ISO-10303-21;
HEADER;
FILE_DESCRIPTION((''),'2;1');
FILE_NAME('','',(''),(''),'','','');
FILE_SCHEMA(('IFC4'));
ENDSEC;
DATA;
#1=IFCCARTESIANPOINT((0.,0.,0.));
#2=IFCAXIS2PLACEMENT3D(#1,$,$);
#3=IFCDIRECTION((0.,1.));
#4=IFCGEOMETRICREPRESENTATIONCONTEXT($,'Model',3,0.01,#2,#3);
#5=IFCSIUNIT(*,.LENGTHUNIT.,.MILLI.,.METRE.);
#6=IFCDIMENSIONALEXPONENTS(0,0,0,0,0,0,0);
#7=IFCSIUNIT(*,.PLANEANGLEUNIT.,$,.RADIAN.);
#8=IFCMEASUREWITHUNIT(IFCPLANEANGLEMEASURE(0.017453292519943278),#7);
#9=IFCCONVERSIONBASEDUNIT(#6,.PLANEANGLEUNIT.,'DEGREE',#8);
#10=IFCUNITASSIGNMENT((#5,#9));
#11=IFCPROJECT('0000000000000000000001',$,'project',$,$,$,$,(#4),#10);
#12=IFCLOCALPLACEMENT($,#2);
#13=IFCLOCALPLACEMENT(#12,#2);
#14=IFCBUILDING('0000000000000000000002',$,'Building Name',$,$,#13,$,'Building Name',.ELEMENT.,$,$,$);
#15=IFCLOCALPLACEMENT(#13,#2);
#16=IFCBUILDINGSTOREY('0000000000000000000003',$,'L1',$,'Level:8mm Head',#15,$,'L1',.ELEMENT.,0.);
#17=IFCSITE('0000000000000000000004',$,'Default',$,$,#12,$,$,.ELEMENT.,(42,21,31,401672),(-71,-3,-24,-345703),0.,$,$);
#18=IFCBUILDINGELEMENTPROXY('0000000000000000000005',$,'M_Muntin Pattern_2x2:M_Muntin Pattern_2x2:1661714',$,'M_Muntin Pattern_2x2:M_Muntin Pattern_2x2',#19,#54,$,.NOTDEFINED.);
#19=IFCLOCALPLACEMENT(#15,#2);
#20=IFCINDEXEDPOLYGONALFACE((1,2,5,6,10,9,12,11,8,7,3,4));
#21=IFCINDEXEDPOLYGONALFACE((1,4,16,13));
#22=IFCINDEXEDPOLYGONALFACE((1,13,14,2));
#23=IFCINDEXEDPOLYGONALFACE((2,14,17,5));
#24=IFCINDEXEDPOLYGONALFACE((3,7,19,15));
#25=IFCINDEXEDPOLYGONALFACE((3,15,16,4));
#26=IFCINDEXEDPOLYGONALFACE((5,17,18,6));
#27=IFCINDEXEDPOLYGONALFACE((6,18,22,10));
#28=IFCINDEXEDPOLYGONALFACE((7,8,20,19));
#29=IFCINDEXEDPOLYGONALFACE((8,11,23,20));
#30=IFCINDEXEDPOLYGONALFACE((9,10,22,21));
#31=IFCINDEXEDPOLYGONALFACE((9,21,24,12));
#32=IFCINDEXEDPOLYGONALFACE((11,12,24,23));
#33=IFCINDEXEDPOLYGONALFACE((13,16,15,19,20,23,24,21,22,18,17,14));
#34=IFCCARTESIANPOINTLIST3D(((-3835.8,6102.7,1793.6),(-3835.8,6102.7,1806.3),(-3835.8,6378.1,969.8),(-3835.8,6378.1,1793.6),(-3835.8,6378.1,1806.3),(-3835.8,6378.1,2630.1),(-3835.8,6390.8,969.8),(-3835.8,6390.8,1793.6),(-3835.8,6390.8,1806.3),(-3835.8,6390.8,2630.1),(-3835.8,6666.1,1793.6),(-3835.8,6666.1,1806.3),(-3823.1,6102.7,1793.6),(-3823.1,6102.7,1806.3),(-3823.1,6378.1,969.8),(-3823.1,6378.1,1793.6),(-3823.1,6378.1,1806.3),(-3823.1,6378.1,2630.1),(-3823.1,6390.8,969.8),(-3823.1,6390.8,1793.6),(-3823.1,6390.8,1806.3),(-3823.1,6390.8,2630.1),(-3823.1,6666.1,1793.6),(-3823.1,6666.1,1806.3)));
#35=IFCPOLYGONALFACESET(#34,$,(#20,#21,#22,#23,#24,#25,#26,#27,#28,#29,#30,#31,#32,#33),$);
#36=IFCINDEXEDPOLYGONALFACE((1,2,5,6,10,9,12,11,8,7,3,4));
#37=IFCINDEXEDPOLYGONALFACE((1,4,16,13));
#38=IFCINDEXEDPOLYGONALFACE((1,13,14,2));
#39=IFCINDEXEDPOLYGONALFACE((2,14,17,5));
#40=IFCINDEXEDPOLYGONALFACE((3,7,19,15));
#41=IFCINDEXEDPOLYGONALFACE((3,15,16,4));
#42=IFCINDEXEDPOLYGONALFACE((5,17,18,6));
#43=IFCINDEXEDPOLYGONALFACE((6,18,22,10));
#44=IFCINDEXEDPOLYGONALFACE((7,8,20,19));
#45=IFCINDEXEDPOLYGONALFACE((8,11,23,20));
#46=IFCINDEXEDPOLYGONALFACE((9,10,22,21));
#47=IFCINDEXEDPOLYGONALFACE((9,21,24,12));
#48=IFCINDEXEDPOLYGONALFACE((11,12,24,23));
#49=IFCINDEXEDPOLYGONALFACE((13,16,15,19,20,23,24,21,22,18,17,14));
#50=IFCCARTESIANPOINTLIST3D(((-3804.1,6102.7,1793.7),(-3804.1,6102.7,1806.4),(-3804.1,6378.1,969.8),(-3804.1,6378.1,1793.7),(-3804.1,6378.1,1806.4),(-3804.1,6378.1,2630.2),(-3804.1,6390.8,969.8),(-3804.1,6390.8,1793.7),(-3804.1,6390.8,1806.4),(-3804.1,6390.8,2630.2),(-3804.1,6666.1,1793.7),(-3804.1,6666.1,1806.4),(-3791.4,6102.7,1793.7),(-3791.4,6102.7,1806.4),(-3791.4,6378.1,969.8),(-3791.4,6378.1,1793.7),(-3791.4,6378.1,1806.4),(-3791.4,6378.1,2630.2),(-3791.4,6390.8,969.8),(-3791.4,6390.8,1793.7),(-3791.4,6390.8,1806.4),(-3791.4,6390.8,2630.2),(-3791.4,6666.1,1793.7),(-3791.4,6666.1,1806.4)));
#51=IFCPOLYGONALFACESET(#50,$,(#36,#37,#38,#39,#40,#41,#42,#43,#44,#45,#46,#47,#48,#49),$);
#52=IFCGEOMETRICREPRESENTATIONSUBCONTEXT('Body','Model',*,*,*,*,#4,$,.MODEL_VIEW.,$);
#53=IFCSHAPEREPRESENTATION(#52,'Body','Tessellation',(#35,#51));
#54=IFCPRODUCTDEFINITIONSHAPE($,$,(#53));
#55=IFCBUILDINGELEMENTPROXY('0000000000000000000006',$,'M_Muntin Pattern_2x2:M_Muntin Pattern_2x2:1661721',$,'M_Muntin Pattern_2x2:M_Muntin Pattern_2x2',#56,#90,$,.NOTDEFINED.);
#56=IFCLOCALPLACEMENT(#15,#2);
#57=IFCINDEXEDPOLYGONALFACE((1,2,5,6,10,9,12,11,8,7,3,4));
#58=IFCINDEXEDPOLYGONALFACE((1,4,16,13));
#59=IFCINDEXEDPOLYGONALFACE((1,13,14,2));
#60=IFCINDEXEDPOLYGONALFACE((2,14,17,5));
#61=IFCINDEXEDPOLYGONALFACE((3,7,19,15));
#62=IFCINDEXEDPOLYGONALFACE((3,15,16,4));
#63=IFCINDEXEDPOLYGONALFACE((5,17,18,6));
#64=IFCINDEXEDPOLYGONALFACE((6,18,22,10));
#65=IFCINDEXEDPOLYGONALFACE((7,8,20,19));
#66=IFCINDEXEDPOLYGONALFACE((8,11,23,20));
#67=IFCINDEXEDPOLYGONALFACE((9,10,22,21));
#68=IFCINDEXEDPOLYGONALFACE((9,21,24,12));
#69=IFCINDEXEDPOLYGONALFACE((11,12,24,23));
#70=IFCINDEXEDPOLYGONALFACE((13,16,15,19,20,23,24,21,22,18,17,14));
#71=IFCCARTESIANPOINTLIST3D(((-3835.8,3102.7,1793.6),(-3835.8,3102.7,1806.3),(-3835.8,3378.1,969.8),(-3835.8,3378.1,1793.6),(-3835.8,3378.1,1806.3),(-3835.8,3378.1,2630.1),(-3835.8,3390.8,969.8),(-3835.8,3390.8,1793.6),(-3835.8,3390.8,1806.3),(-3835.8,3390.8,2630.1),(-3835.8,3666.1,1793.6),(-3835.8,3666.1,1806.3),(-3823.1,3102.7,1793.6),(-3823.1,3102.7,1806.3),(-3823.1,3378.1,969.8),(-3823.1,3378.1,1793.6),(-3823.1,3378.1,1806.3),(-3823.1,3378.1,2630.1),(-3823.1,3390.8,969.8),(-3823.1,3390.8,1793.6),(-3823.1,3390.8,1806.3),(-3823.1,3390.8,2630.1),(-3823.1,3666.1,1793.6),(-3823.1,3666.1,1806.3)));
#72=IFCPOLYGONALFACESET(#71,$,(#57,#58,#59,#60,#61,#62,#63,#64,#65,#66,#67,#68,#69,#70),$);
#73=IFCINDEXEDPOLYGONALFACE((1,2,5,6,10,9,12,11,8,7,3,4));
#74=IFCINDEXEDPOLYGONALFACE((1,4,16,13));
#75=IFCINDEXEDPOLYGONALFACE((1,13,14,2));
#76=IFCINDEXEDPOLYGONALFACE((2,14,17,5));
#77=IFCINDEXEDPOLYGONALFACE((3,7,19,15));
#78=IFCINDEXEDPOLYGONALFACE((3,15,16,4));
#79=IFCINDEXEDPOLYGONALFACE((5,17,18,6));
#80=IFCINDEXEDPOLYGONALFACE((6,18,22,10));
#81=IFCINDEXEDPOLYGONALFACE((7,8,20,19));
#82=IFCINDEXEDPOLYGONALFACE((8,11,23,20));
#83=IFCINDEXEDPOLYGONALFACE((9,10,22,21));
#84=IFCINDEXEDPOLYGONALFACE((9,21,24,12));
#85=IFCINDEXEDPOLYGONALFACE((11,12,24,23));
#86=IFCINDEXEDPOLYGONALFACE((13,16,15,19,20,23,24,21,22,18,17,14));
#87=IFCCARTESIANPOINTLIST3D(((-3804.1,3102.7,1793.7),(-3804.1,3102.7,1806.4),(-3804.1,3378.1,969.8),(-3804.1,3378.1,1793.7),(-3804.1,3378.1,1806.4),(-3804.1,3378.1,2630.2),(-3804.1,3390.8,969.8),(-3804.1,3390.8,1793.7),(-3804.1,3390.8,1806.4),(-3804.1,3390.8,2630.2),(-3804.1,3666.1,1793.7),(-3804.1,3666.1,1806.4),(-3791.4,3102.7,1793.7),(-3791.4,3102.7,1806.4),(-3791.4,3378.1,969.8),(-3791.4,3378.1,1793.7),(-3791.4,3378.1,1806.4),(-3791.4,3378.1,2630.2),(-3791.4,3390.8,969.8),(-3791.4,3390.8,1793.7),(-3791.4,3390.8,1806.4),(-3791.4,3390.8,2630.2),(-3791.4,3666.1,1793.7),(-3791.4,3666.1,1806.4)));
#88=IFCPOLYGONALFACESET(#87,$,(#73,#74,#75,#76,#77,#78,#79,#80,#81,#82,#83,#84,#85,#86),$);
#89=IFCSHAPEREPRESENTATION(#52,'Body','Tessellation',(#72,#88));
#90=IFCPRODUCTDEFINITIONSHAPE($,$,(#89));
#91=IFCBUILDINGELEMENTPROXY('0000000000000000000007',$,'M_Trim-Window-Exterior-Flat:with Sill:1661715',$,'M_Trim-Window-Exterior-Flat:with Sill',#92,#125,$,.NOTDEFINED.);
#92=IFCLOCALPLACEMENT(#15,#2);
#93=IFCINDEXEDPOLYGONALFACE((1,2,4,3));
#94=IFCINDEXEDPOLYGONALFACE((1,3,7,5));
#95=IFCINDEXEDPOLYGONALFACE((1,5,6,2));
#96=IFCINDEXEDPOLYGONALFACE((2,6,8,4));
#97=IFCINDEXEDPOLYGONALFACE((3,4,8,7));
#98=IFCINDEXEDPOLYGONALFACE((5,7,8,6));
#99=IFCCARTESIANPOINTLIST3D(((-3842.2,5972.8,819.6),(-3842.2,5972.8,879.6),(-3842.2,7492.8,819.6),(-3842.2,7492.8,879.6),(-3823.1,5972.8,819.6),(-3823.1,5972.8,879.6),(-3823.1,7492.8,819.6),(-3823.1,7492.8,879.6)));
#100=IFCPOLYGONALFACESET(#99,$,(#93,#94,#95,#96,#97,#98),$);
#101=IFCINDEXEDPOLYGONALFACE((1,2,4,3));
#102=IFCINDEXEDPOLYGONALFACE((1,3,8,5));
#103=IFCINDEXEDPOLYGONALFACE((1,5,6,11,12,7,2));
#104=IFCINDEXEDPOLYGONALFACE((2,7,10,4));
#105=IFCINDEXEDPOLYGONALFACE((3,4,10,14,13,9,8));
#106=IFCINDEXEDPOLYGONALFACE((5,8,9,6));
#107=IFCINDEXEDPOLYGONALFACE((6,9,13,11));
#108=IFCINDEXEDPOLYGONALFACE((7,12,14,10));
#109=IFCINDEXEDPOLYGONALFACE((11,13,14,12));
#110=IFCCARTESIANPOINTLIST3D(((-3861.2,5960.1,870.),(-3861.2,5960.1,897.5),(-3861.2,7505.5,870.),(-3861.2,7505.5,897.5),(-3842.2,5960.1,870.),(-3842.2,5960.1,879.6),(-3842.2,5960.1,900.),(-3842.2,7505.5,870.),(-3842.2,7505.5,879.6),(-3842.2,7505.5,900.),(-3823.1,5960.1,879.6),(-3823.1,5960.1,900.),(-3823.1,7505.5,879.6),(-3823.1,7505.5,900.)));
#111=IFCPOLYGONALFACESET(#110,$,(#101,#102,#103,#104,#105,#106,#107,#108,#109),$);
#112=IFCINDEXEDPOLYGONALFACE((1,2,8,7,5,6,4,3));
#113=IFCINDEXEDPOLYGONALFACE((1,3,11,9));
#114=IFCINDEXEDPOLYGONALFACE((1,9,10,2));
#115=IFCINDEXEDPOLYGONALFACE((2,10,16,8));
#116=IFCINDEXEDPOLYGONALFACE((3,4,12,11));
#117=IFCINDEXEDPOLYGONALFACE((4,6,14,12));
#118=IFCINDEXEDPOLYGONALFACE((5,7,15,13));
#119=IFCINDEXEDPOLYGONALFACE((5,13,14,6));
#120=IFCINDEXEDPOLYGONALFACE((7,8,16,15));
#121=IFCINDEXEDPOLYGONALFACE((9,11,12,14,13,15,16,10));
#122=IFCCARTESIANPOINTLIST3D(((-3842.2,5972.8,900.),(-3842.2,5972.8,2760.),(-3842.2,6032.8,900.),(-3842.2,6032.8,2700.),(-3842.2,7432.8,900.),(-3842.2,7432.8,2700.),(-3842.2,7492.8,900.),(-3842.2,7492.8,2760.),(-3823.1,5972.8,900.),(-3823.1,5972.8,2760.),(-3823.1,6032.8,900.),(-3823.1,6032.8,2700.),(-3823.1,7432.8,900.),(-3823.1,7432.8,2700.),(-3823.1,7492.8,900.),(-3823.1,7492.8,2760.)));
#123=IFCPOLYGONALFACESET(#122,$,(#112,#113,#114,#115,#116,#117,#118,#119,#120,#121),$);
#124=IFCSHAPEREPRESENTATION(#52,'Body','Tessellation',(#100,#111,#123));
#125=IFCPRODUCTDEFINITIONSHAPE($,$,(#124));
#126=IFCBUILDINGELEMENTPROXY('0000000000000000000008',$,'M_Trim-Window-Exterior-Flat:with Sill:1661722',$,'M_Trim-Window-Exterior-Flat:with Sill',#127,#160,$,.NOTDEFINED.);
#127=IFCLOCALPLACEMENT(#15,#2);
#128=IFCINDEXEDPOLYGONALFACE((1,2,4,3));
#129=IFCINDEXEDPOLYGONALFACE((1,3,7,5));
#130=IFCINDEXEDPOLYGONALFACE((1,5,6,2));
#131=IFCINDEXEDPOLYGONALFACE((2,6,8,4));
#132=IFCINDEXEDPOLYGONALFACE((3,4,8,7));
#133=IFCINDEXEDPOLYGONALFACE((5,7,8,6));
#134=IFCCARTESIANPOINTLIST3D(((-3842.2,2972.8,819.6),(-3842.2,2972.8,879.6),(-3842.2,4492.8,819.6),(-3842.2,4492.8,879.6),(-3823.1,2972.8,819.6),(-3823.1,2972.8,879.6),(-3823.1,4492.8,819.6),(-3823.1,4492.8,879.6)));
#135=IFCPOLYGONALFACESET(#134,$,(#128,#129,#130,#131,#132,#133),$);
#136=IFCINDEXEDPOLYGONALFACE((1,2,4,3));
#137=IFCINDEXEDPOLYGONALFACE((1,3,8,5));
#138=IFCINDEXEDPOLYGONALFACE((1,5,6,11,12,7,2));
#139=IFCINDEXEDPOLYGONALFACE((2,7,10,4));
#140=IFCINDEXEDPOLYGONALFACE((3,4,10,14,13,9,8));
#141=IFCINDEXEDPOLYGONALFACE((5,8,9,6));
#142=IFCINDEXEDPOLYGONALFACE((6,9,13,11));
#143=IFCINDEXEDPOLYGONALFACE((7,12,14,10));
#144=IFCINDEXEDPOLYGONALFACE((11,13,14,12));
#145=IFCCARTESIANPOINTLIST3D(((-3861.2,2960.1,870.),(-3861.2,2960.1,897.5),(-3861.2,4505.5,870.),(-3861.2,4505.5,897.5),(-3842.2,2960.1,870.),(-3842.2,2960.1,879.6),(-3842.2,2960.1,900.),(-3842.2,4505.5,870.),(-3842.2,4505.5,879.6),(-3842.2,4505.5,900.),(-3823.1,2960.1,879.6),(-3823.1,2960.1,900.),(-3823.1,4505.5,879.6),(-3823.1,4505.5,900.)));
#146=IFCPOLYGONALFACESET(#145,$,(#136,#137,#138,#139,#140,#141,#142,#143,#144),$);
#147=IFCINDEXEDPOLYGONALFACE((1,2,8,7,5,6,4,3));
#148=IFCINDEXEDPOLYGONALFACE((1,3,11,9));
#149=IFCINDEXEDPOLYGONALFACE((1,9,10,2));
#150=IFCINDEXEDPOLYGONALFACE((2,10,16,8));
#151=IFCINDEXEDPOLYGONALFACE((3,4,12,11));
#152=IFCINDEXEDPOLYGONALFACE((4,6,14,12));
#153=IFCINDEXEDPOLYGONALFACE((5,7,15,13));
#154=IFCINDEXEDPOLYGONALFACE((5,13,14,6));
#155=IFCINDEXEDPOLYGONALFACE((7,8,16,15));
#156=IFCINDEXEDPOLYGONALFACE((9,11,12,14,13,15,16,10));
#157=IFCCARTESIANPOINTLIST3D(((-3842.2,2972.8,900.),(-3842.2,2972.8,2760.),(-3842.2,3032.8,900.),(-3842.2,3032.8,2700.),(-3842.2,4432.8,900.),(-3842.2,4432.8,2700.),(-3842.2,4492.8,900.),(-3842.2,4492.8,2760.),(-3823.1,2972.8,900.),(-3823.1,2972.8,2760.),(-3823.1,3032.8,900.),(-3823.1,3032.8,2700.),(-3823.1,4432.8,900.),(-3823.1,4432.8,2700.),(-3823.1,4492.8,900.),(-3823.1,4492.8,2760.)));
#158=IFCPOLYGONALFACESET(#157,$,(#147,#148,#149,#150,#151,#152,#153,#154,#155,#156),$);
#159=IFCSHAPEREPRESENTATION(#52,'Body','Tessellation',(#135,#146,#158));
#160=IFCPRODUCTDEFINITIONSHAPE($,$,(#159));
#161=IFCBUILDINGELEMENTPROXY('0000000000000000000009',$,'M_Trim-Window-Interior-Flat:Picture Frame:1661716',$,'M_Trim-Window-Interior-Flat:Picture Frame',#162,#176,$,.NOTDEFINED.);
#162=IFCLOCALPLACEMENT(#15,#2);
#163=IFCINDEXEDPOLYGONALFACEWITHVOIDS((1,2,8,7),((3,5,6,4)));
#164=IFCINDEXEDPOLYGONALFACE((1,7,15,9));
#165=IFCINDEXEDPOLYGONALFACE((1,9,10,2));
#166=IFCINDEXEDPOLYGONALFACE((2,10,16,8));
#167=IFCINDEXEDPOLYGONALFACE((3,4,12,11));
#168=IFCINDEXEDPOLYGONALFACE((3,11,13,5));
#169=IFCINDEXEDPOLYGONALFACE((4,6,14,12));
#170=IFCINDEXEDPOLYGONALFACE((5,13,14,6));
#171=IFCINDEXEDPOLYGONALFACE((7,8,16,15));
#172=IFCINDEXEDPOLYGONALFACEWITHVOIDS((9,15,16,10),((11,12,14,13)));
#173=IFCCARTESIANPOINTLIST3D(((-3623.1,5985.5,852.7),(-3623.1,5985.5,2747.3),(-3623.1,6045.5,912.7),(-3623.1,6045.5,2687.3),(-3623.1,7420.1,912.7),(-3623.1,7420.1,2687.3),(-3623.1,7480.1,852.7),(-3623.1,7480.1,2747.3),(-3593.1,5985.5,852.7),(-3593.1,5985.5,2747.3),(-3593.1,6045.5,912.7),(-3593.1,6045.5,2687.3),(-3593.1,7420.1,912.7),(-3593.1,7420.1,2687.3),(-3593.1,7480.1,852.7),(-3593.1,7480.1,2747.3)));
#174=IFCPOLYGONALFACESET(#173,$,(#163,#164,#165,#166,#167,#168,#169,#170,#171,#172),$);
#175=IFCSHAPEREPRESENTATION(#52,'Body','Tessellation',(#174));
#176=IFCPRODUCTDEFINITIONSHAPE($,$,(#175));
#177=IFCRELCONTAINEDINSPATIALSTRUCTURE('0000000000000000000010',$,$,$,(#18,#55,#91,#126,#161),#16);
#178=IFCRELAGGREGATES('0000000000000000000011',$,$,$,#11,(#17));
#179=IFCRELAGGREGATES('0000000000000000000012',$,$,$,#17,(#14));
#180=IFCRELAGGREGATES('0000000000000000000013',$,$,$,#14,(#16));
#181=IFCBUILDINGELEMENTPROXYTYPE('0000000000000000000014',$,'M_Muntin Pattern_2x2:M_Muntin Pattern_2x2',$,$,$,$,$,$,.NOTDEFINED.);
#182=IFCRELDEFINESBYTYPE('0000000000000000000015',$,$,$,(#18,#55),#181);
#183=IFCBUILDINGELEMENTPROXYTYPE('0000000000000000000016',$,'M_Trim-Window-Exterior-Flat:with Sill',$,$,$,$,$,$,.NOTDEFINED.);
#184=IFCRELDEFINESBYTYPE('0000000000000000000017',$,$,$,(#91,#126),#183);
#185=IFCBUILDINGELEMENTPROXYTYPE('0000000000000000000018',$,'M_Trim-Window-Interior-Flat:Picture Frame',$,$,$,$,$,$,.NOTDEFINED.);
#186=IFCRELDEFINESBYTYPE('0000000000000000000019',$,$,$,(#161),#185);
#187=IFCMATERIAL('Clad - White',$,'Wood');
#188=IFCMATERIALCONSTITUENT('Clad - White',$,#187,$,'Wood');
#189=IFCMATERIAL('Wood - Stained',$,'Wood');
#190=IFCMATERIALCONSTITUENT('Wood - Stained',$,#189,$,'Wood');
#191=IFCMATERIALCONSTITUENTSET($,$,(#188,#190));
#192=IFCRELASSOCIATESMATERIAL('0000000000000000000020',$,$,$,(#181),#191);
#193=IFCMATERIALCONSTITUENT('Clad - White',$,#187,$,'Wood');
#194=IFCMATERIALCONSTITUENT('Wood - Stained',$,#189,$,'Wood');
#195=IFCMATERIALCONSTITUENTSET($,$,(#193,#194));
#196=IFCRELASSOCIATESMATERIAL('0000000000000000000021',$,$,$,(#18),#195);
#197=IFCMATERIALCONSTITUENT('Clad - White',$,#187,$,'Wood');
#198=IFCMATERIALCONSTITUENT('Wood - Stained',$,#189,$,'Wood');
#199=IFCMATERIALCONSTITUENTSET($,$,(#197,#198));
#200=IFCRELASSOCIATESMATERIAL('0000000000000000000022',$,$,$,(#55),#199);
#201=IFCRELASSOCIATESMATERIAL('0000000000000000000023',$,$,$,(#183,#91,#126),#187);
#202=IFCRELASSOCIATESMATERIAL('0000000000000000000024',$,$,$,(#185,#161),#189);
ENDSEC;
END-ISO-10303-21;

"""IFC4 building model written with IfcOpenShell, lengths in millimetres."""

from ifc_helpers import new_model, entity, si_unit, converted_unit, direction, frame, origin, place, context, subcontext, project, spatial, indexed_curve, outline, extrude, source, transform, mapped, material, constituent, constituent_set, type_object, type_shapes, element, save


model = new_model("IFC4")

# Units and contexts
model_context = context("Model", 3, precision=0.01, world=origin(), true_north=direction((0.0, 1.0)))
body_context = subcontext(model_context, "Body", "Model", "MODEL_VIEW")
ifc_project = project(units=[si_unit("LENGTHUNIT", "METRE", prefix="MILLI"), converted_unit("PLANEANGLEUNIT", "DEGREE", entity("IfcPlaneAngleMeasure", 0.017453292519943278), si_unit("PLANEANGLEUNIT", "RADIAN"), dimensions=[0, 0, 0, 0, 0, 0, 0])], contexts=[model_context])

# Site, building, storey
site_placement = place(None, origin())
site = spatial("IfcSite", under=ifc_project, at=site_placement, Name="Default", CompositionType="ELEMENT", RefLatitude=(42, 21, 31, 401672), RefLongitude=(-71, -3, -24, -345703), RefElevation=0.0)
building_placement = place(site_placement, origin())
building = spatial("IfcBuilding", under=site, at=building_placement, Name="Building Name", LongName="Building Name", CompositionType="ELEMENT")
storey_placement = place(building_placement, origin())
storey = spatial("IfcBuildingStorey", under=building, at=storey_placement, Name="L1", ObjectType="Level:8mm Head", LongName="L1", CompositionType="ELEMENT", Elevation=0.0)

# Building element proxies
ifc_material_1 = material(Name="Clad - White", Category="Wood")
ifc_material_2 = material(Name="Wood - Stained", Category="Wood")
ifc_constituent_1 = constituent(ifc_material_1, Name="Clad - White", Category="Wood")
ifc_constituent_2 = constituent(ifc_material_2, Name="Wood - Stained", Category="Wood")
ifc_constituent_set_1 = constituent_set(constituents=[ifc_constituent_1, ifc_constituent_2])
ifc_constituent_3 = constituent(ifc_material_1, Name="Clad - White", Category="Wood")
ifc_constituent_4 = constituent(ifc_material_2, Name="Wood - Stained", Category="Wood")
ifc_constituent_set_2 = constituent_set(constituents=[ifc_constituent_3, ifc_constituent_4])
building_element_proxy_type_1 = type_object("IfcBuildingElementProxyType", Name="M_Muntin Pattern_2x2:M_Muntin Pattern_2x2", PredefinedType="NOTDEFINED", material=ifc_constituent_set_2)
shared_shape_1 = source(origin(), body_context, "Body", "SweptSolid", [
    extrude(outline(indexed_curve([(6.4, -6.4), (830.1, -6.4), (830.1, 6.3), (6.4, 6.3), (6.4, 281.7), (-6.3, 281.7), (-6.3, 6.3), (-830.2, 6.3), (-830.2, -6.4), (-6.3, -6.4), (-6.3, -281.7), (6.4, -281.7), (6.4, -6.4)], self_intersect=False)), frame((0.0, 9.5, 830.1), z_axis=(0.0, 1.0, 0.0), x_axis=(0.0, 0.0, 1.0)), (0.0, 0.0, 1.0), 12.7),
    extrude(outline(indexed_curve([(6.4, -6.4), (830.2, -6.4), (830.2, 6.3), (6.4, 6.3), (6.4, 281.7), (-6.3, 281.7), (-6.3, 6.3), (-830.2, 6.3), (-830.2, -6.4), (-6.3, -6.4), (-6.3, -281.7), (6.4, -281.7), (6.4, -6.4)], self_intersect=False)), frame((0.0, -22.2, 830.2), z_axis=(0.0, 1.0, 0.0), x_axis=(0.0, 0.0, 1.0)), (0.0, 0.0, 1.0), 12.7),
])
type_shapes(building_element_proxy_type_1, [shared_shape_1])
proxy_1_placement = place(storey_placement, frame((-3813.6, 6384.4, 969.8), z_axis=(0.0, 0.0, 1.0), x_axis=(0.0, 1.0, 0.0)))
element("IfcBuildingElementProxy", 1, at=proxy_1_placement, inside=storey, type_object=building_element_proxy_type_1, material=ifc_constituent_set_1, Name="M_Muntin Pattern_2x2:M_Muntin Pattern_2x2:1661714", ObjectType="M_Muntin Pattern_2x2:M_Muntin Pattern_2x2", PredefinedType="NOTDEFINED", context=body_context, shape_type="MappedRepresentation", body=[
    mapped(shared_shape_1, transform((0.0, 0.0, 0.0), scale=1.0)),
])
ifc_constituent_5 = constituent(ifc_material_1, Name="Clad - White", Category="Wood")
ifc_constituent_6 = constituent(ifc_material_2, Name="Wood - Stained", Category="Wood")
ifc_constituent_set_3 = constituent_set(constituents=[ifc_constituent_5, ifc_constituent_6])
proxy_2_placement = place(storey_placement, frame((-3813.6, 3384.4, 969.8), z_axis=(0.0, 0.0, 1.0), x_axis=(0.0, 1.0, 0.0)))
element("IfcBuildingElementProxy", 2, at=proxy_2_placement, inside=storey, type_object=building_element_proxy_type_1, material=ifc_constituent_set_3, Name="M_Muntin Pattern_2x2:M_Muntin Pattern_2x2:1661721", ObjectType="M_Muntin Pattern_2x2:M_Muntin Pattern_2x2", PredefinedType="NOTDEFINED", context=body_context, shape_type="MappedRepresentation", body=[
    mapped(shared_shape_1, transform((0.0, 0.0, 0.0), scale=1.0)),
])
building_element_proxy_type_2 = type_object("IfcBuildingElementProxyType", Name="M_Trim-Window-Exterior-Flat:with Sill", PredefinedType="NOTDEFINED", material=ifc_material_1)
shared_shape_2 = source(origin(), body_context, "Body", "SweptSolid", [
    extrude(outline(indexed_curve([(-760.0, -30.0), (760.0, -30.0), (760.0, 30.0), (-760.0, 30.0), (-760.0, -30.0)], self_intersect=False)), frame((0.0, -1850.4, 0.0), z_axis=(0.0, 0.0, 1.0), x_axis=(-1.0, 0.0, 0.0)), (0.0, 0.0, 1.0), 19.0),
    extrude(outline(indexed_curve([(-19.0, -15.2), (0.0, -15.2), (0.0, -5.7), (19.0, -5.7), (19.0, 14.8), (0.0, 14.8), (-19.0, 12.3), (-19.0, -15.2)], self_intersect=False)), frame((-772.7, -1814.8, 19.0), z_axis=(1.0, 0.0, 0.0), x_axis=(0.0, 0.0, -1.0)), (0.0, 0.0, 1.0), 1545.4),
    extrude(outline(indexed_curve([(-945.0, -760.0), (915.0, -760.0), (915.0, -700.0), (-885.0, -700.0), (-885.0, 700.0), (915.0, 700.0), (915.0, 760.0), (-945.0, 760.0), (-945.0, -760.0)], self_intersect=False)), frame((0.0, -885.0, 0.0), z_axis=(0.0, 0.0, 1.0), x_axis=(0.0, -1.0, 0.0)), (0.0, 0.0, 1.0), 19.0),
])
type_shapes(building_element_proxy_type_2, [shared_shape_2])
for number, where, z_axis, x_axis, name in (
    (3, (-3823.1, 6732.8, 2700.0), (-1.0, 0.0, 0.0), (0.0, -1.0, 0.0), "M_Trim-Window-Exterior-Flat:with Sill:1661715"),
    (4, (-3823.1, 3732.8, 2700.0), (-1.0, 0.0, 0.0), (0.0, -1.0, 0.0), "M_Trim-Window-Exterior-Flat:with Sill:1661722"),
):
    element("IfcBuildingElementProxy", number, at=place(storey_placement, frame(where, z_axis=z_axis, x_axis=x_axis)), inside=storey, type_object=building_element_proxy_type_2, material=ifc_material_1, Name=name, ObjectType="M_Trim-Window-Exterior-Flat:with Sill", PredefinedType="NOTDEFINED", context=body_context, shape_type="MappedRepresentation", body=[
        mapped(shared_shape_2, transform((0.0, 0.0, 0.0), scale=1.0)),
    ])
building_element_proxy_type_3 = type_object("IfcBuildingElementProxyType", Name="M_Trim-Window-Interior-Flat:Picture Frame", PredefinedType="NOTDEFINED", material=ifc_material_2)
shared_shape_3 = source(origin(), body_context, "Body", "SweptSolid", [
    extrude(outline(indexed_curve([(-747.3, -947.3), (747.3, -947.3), (747.3, 947.3), (-747.3, 947.3), (-747.3, -947.3)], self_intersect=False), holes=[indexed_curve([(-687.3, -887.3), (-687.3, 887.3), (687.3, 887.3), (687.3, -887.3), (-687.3, -887.3)], self_intersect=False)]), frame((0.0, -900.0, 0.0), z_axis=(0.0, 0.0, 1.0), x_axis=(-1.0, 0.0, 0.0)), (0.0, 0.0, 1.0), 30.0),
])
type_shapes(building_element_proxy_type_3, [shared_shape_3])
for number, where, z_axis, x_axis, name in (
    (5, (-3623.1, 6732.8, 2700.0), (1.0, 0.0, 0.0), (0.0, 1.0, 0.0), "M_Trim-Window-Interior-Flat:Picture Frame:1661716"),
):
    element("IfcBuildingElementProxy", number, at=place(storey_placement, frame(where, z_axis=z_axis, x_axis=x_axis)), inside=storey, type_object=building_element_proxy_type_3, material=ifc_material_2, Name=name, ObjectType="M_Trim-Window-Interior-Flat:Picture Frame", PredefinedType="NOTDEFINED", context=body_context, shape_type="MappedRepresentation", body=[
        mapped(shared_shape_3, transform((0.0, 0.0, 0.0), scale=1.0)),
    ])

save(model, "model.ifc")
